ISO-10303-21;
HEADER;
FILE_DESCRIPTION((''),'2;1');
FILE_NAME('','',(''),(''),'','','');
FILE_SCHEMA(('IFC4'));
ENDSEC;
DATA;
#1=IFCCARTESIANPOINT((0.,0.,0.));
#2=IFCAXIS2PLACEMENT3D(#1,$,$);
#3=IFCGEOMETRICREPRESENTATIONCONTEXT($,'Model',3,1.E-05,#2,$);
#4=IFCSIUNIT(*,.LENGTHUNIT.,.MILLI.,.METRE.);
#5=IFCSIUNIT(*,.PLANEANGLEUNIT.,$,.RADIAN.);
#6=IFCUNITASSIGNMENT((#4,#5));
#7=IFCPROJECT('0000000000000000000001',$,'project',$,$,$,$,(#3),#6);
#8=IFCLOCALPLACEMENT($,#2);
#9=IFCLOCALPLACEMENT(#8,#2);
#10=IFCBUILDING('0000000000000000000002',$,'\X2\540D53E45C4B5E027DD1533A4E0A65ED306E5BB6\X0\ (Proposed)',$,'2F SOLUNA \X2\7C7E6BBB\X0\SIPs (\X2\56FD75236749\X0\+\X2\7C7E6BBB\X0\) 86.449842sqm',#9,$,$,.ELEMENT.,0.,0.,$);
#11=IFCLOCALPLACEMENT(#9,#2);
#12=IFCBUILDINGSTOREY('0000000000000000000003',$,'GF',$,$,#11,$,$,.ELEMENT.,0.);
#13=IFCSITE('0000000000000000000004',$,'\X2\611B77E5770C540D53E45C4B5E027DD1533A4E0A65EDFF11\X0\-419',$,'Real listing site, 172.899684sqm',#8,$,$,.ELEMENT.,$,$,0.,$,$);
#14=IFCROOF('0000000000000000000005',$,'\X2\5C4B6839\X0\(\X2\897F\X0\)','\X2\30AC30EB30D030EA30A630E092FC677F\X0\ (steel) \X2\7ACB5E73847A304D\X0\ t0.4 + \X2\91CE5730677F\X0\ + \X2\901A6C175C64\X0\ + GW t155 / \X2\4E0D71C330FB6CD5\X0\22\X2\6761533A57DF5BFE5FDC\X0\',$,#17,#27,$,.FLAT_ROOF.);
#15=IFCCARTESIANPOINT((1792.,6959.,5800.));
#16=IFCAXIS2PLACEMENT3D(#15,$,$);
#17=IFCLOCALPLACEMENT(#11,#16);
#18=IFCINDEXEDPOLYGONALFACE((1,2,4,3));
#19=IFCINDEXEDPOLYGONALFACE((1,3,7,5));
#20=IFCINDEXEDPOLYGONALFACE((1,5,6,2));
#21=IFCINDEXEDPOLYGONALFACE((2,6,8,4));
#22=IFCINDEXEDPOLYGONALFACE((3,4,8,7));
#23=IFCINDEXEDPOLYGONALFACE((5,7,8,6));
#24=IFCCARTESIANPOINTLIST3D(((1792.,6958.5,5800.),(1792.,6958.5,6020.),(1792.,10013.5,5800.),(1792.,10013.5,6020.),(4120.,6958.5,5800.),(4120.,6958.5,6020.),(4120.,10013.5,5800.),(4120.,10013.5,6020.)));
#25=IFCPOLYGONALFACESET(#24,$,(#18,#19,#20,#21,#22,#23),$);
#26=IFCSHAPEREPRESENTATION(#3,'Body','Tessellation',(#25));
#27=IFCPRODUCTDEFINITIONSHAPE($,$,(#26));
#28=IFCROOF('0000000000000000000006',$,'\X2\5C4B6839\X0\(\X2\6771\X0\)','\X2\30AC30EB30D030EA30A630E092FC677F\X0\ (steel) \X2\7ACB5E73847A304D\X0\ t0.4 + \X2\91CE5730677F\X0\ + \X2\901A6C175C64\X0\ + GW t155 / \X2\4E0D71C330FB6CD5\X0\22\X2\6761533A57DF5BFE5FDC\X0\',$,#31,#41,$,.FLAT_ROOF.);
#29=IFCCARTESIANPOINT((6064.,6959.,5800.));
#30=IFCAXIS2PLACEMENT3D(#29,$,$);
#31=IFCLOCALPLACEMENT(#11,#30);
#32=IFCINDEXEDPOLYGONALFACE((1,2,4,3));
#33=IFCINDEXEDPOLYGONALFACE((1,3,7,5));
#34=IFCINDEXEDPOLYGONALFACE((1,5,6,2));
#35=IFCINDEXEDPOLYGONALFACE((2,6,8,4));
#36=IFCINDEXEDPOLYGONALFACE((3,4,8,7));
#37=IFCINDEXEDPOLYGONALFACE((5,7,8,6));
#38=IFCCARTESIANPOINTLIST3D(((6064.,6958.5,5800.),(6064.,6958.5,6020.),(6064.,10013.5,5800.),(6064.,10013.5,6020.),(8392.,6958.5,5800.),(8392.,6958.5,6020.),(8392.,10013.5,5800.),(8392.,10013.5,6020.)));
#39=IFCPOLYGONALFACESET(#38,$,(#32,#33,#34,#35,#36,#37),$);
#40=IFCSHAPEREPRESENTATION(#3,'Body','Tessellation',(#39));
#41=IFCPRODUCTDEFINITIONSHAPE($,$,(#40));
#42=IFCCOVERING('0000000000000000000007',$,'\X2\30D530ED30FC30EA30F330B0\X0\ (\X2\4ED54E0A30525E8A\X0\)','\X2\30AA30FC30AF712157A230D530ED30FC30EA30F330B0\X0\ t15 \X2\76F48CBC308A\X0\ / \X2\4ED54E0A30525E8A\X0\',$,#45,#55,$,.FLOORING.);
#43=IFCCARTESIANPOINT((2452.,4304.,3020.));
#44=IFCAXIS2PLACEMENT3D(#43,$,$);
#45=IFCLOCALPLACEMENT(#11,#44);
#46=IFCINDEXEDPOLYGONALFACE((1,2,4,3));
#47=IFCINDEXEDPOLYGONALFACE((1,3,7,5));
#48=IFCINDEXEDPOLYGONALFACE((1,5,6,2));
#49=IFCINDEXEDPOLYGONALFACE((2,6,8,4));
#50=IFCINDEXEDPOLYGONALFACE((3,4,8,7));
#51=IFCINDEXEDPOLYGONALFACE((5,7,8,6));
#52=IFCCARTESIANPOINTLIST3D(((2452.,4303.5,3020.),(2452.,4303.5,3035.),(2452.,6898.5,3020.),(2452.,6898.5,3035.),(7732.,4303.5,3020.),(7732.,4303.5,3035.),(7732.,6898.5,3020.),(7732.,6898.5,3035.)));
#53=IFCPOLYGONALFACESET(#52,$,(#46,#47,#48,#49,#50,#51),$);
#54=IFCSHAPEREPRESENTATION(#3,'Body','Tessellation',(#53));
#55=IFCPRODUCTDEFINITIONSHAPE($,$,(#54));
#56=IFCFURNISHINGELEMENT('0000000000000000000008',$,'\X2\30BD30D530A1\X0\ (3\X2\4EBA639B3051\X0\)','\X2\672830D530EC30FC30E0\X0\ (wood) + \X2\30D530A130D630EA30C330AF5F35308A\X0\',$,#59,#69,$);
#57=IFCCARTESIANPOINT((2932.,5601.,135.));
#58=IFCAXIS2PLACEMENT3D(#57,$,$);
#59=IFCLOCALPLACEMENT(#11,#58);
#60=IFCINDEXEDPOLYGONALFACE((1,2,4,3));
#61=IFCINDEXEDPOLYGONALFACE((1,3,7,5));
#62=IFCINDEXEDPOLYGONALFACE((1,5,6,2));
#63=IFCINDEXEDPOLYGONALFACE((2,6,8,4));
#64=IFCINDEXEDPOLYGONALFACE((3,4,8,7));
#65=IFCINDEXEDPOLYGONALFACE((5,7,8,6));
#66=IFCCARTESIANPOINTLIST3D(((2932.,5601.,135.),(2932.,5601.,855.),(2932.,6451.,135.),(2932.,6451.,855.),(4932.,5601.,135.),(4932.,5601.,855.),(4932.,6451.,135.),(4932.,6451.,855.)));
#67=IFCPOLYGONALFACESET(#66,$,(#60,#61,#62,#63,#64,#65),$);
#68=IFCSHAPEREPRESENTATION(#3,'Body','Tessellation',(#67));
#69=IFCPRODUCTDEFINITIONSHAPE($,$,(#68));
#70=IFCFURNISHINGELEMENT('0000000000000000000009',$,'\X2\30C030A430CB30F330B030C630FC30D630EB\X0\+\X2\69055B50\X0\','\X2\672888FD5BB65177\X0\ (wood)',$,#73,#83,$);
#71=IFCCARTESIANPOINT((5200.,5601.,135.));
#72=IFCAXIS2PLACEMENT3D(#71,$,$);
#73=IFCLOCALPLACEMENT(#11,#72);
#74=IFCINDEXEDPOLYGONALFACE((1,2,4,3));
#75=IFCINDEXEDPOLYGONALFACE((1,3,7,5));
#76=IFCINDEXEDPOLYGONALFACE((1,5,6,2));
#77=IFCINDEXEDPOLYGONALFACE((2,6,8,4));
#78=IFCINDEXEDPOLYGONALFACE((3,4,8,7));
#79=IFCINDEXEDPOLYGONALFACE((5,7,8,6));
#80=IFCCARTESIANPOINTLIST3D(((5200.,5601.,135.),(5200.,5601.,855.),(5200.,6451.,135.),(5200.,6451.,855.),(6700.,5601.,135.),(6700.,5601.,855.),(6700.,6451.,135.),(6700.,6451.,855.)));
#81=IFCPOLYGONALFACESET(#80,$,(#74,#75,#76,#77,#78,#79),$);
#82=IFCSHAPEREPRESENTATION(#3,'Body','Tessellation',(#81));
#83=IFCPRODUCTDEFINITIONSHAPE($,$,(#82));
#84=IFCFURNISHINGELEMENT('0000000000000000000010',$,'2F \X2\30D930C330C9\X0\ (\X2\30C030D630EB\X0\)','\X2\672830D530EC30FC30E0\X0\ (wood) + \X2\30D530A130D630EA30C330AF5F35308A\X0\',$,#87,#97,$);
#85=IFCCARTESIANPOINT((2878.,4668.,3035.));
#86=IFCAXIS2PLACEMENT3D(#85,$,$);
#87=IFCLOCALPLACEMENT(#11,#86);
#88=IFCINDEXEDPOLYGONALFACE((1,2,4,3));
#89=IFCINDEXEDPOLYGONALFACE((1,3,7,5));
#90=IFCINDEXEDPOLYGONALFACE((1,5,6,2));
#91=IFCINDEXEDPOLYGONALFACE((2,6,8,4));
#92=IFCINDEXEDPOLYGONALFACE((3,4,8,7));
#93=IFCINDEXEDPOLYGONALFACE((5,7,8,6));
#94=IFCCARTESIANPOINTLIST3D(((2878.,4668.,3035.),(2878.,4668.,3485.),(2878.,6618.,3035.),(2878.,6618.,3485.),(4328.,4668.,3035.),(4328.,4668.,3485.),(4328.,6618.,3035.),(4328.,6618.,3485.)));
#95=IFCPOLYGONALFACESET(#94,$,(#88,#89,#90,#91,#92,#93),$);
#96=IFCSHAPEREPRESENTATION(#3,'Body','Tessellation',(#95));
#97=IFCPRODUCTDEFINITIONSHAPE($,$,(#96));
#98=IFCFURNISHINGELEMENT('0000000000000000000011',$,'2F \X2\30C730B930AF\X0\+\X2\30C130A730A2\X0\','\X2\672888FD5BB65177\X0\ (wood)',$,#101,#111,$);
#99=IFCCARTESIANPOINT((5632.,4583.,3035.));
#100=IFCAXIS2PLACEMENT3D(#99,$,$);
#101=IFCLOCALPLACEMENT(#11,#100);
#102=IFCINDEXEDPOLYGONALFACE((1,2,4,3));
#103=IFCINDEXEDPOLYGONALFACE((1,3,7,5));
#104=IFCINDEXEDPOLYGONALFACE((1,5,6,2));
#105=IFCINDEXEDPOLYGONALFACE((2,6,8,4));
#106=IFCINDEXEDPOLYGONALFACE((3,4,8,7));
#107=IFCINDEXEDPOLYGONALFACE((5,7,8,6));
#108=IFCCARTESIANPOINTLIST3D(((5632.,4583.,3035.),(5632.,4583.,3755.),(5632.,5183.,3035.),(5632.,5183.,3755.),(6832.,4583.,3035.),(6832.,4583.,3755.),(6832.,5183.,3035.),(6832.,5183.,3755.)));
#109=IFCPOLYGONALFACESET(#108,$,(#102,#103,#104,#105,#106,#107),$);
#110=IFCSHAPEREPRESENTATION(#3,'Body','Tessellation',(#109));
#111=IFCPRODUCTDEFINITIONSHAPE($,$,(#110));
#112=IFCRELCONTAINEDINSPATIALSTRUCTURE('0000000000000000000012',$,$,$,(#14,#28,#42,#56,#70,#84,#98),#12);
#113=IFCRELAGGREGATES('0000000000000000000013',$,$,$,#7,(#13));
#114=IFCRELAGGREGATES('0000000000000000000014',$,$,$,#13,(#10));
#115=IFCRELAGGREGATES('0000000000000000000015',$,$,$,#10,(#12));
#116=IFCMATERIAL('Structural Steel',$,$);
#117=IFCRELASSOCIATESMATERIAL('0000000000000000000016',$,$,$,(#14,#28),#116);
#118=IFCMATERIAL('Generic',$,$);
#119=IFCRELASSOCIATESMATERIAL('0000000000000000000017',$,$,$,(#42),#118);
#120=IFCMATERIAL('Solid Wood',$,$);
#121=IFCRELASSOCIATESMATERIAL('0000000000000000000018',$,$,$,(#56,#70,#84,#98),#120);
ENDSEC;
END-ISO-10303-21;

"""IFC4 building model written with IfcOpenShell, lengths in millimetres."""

from ifc_helpers import new_model, si_unit, frame, frame_2d, origin, place, context, project, spatial, rectangle, extrude, material, element, save


model = new_model("IFC4")

# Units and contexts
model_context = context("Model", 3, precision=1e-05, world=origin())
ifc_project = project(units=[si_unit("LENGTHUNIT", "METRE", prefix="MILLI"), si_unit("PLANEANGLEUNIT", "RADIAN")], contexts=[model_context])

# Site, building, storey
site_placement = place(None, origin())
site = spatial("IfcSite", under=ifc_project, at=site_placement, Name="愛知県名古屋市緑区上旭１-419", ObjectType="Real listing site, 172.899684sqm", CompositionType="ELEMENT", RefElevation=0.0)
building_placement = place(site_placement, origin())
building = spatial("IfcBuilding", under=site, at=building_placement, Name="名古屋市緑区上旭の家 (Proposed)", ObjectType="2F SOLUNA 籾殻SIPs (国産杉+籾殻) 86.449842sqm", CompositionType="ELEMENT", ElevationOfRefHeight=0.0, ElevationOfTerrain=0.0)
storey_placement = place(building_placement, origin())
storey = spatial("IfcBuildingStorey", under=building, at=storey_placement, Name="GF", CompositionType="ELEMENT", Elevation=0.0)

# Shared definitions
ifc_material_1 = material(Name="Solid Wood")

# Roofs
ifc_material_2 = material(Name="Structural Steel")
roof_1_placement = place(storey_placement, frame((1792.0, 6959.0, 5800.0)))
element("IfcRoof", 1, at=roof_1_placement, inside=storey, material=ifc_material_2, Name="屋根(西)", Description="ガルバリウム鋼板 (steel) 立平葺き t0.4 + 野地板 + 通気層 + GW t155 / 不燃・法22条区域対応", PredefinedType="FLAT_ROOF", context=model_context, shape_type="SweptSolid", body=[
    extrude(rectangle(XDim=2328.0, YDim=3055.0, at=frame_2d((1164.0, 1527.0))), frame((1792.0, 6959.0, 5800.0)), (0.0, 0.0, 1.0), 220.0),
])
roof_2_placement = place(storey_placement, frame((6064.0, 6959.0, 5800.0)))
element("IfcRoof", 2, at=roof_2_placement, inside=storey, material=ifc_material_2, Name="屋根(東)", Description="ガルバリウム鋼板 (steel) 立平葺き t0.4 + 野地板 + 通気層 + GW t155 / 不燃・法22条区域対応", PredefinedType="FLAT_ROOF", context=model_context, shape_type="SweptSolid", body=[
    extrude(rectangle(XDim=2328.0, YDim=3055.0, at=frame_2d((1164.0, 1527.0))), frame((6064.0, 6959.0, 5800.0)), (0.0, 0.0, 1.0), 220.0),
])

# Covering
ifc_material_3 = material(Name="Generic")
covering_placement = place(storey_placement, frame((2452.0, 4304.0, 3020.0)))
element("IfcCovering", 3, at=covering_placement, inside=storey, material=ifc_material_3, Name="フローリング (仕上げ床)", Description="オーク無垢フローリング t15 直貼り / 仕上げ床", PredefinedType="FLOORING", context=model_context, shape_type="SweptSolid", body=[
    extrude(rectangle(XDim=5280.0, YDim=2595.0, at=frame_2d((2640.0, 1297.0))), frame((2452.0, 4304.0, 3020.0)), (0.0, 0.0, 1.0), 15.0),
])

# Furnishing elements
furnishing_1_placement = place(storey_placement, frame((2932.0, 5601.0, 135.0)))
element("IfcFurnishingElement", 4, at=furnishing_1_placement, inside=storey, material=ifc_material_1, Name="ソファ (3人掛け)", Description="木フレーム (wood) + ファブリック張り", context=model_context, shape_type="SweptSolid", body=[
    extrude(rectangle(XDim=2000.0, YDim=850.0, at=frame_2d((1000.0, 425.0))), frame((2932.0, 5601.0, 135.0)), (0.0, 0.0, 1.0), 720.0),
])
furnishing_2_placement = place(storey_placement, frame((5200.0, 5601.0, 135.0)))
element("IfcFurnishingElement", 5, at=furnishing_2_placement, inside=storey, material=ifc_material_1, Name="ダイニングテーブル+椅子", Description="木製家具 (wood)", context=model_context, shape_type="SweptSolid", body=[
    extrude(rectangle(XDim=1500.0, YDim=850.0, at=frame_2d((750.0, 425.0))), frame((5200.0, 5601.0, 135.0)), (0.0, 0.0, 1.0), 720.0),
])
furnishing_3_placement = place(storey_placement, frame((2878.0, 4668.0, 3035.0)))
element("IfcFurnishingElement", 6, at=furnishing_3_placement, inside=storey, material=ifc_material_1, Name="2F ベッド (ダブル)", Description="木フレーム (wood) + ファブリック張り", context=model_context, shape_type="SweptSolid", body=[
    extrude(rectangle(XDim=1450.0, YDim=1950.0, at=frame_2d((725.0, 975.0))), frame((2878.0, 4668.0, 3035.0)), (0.0, 0.0, 1.0), 450.0),
])
furnishing_4_placement = place(storey_placement, frame((5632.0, 4583.0, 3035.0)))
element("IfcFurnishingElement", 7, at=furnishing_4_placement, inside=storey, material=ifc_material_1, Name="2F デスク+チェア", Description="木製家具 (wood)", context=model_context, shape_type="SweptSolid", body=[
    extrude(rectangle(XDim=1200.0, YDim=600.0, at=frame_2d((600.0, 300.0))), frame((5632.0, 4583.0, 3035.0)), (0.0, 0.0, 1.0), 720.0),
])

save(model, "model.ifc")
